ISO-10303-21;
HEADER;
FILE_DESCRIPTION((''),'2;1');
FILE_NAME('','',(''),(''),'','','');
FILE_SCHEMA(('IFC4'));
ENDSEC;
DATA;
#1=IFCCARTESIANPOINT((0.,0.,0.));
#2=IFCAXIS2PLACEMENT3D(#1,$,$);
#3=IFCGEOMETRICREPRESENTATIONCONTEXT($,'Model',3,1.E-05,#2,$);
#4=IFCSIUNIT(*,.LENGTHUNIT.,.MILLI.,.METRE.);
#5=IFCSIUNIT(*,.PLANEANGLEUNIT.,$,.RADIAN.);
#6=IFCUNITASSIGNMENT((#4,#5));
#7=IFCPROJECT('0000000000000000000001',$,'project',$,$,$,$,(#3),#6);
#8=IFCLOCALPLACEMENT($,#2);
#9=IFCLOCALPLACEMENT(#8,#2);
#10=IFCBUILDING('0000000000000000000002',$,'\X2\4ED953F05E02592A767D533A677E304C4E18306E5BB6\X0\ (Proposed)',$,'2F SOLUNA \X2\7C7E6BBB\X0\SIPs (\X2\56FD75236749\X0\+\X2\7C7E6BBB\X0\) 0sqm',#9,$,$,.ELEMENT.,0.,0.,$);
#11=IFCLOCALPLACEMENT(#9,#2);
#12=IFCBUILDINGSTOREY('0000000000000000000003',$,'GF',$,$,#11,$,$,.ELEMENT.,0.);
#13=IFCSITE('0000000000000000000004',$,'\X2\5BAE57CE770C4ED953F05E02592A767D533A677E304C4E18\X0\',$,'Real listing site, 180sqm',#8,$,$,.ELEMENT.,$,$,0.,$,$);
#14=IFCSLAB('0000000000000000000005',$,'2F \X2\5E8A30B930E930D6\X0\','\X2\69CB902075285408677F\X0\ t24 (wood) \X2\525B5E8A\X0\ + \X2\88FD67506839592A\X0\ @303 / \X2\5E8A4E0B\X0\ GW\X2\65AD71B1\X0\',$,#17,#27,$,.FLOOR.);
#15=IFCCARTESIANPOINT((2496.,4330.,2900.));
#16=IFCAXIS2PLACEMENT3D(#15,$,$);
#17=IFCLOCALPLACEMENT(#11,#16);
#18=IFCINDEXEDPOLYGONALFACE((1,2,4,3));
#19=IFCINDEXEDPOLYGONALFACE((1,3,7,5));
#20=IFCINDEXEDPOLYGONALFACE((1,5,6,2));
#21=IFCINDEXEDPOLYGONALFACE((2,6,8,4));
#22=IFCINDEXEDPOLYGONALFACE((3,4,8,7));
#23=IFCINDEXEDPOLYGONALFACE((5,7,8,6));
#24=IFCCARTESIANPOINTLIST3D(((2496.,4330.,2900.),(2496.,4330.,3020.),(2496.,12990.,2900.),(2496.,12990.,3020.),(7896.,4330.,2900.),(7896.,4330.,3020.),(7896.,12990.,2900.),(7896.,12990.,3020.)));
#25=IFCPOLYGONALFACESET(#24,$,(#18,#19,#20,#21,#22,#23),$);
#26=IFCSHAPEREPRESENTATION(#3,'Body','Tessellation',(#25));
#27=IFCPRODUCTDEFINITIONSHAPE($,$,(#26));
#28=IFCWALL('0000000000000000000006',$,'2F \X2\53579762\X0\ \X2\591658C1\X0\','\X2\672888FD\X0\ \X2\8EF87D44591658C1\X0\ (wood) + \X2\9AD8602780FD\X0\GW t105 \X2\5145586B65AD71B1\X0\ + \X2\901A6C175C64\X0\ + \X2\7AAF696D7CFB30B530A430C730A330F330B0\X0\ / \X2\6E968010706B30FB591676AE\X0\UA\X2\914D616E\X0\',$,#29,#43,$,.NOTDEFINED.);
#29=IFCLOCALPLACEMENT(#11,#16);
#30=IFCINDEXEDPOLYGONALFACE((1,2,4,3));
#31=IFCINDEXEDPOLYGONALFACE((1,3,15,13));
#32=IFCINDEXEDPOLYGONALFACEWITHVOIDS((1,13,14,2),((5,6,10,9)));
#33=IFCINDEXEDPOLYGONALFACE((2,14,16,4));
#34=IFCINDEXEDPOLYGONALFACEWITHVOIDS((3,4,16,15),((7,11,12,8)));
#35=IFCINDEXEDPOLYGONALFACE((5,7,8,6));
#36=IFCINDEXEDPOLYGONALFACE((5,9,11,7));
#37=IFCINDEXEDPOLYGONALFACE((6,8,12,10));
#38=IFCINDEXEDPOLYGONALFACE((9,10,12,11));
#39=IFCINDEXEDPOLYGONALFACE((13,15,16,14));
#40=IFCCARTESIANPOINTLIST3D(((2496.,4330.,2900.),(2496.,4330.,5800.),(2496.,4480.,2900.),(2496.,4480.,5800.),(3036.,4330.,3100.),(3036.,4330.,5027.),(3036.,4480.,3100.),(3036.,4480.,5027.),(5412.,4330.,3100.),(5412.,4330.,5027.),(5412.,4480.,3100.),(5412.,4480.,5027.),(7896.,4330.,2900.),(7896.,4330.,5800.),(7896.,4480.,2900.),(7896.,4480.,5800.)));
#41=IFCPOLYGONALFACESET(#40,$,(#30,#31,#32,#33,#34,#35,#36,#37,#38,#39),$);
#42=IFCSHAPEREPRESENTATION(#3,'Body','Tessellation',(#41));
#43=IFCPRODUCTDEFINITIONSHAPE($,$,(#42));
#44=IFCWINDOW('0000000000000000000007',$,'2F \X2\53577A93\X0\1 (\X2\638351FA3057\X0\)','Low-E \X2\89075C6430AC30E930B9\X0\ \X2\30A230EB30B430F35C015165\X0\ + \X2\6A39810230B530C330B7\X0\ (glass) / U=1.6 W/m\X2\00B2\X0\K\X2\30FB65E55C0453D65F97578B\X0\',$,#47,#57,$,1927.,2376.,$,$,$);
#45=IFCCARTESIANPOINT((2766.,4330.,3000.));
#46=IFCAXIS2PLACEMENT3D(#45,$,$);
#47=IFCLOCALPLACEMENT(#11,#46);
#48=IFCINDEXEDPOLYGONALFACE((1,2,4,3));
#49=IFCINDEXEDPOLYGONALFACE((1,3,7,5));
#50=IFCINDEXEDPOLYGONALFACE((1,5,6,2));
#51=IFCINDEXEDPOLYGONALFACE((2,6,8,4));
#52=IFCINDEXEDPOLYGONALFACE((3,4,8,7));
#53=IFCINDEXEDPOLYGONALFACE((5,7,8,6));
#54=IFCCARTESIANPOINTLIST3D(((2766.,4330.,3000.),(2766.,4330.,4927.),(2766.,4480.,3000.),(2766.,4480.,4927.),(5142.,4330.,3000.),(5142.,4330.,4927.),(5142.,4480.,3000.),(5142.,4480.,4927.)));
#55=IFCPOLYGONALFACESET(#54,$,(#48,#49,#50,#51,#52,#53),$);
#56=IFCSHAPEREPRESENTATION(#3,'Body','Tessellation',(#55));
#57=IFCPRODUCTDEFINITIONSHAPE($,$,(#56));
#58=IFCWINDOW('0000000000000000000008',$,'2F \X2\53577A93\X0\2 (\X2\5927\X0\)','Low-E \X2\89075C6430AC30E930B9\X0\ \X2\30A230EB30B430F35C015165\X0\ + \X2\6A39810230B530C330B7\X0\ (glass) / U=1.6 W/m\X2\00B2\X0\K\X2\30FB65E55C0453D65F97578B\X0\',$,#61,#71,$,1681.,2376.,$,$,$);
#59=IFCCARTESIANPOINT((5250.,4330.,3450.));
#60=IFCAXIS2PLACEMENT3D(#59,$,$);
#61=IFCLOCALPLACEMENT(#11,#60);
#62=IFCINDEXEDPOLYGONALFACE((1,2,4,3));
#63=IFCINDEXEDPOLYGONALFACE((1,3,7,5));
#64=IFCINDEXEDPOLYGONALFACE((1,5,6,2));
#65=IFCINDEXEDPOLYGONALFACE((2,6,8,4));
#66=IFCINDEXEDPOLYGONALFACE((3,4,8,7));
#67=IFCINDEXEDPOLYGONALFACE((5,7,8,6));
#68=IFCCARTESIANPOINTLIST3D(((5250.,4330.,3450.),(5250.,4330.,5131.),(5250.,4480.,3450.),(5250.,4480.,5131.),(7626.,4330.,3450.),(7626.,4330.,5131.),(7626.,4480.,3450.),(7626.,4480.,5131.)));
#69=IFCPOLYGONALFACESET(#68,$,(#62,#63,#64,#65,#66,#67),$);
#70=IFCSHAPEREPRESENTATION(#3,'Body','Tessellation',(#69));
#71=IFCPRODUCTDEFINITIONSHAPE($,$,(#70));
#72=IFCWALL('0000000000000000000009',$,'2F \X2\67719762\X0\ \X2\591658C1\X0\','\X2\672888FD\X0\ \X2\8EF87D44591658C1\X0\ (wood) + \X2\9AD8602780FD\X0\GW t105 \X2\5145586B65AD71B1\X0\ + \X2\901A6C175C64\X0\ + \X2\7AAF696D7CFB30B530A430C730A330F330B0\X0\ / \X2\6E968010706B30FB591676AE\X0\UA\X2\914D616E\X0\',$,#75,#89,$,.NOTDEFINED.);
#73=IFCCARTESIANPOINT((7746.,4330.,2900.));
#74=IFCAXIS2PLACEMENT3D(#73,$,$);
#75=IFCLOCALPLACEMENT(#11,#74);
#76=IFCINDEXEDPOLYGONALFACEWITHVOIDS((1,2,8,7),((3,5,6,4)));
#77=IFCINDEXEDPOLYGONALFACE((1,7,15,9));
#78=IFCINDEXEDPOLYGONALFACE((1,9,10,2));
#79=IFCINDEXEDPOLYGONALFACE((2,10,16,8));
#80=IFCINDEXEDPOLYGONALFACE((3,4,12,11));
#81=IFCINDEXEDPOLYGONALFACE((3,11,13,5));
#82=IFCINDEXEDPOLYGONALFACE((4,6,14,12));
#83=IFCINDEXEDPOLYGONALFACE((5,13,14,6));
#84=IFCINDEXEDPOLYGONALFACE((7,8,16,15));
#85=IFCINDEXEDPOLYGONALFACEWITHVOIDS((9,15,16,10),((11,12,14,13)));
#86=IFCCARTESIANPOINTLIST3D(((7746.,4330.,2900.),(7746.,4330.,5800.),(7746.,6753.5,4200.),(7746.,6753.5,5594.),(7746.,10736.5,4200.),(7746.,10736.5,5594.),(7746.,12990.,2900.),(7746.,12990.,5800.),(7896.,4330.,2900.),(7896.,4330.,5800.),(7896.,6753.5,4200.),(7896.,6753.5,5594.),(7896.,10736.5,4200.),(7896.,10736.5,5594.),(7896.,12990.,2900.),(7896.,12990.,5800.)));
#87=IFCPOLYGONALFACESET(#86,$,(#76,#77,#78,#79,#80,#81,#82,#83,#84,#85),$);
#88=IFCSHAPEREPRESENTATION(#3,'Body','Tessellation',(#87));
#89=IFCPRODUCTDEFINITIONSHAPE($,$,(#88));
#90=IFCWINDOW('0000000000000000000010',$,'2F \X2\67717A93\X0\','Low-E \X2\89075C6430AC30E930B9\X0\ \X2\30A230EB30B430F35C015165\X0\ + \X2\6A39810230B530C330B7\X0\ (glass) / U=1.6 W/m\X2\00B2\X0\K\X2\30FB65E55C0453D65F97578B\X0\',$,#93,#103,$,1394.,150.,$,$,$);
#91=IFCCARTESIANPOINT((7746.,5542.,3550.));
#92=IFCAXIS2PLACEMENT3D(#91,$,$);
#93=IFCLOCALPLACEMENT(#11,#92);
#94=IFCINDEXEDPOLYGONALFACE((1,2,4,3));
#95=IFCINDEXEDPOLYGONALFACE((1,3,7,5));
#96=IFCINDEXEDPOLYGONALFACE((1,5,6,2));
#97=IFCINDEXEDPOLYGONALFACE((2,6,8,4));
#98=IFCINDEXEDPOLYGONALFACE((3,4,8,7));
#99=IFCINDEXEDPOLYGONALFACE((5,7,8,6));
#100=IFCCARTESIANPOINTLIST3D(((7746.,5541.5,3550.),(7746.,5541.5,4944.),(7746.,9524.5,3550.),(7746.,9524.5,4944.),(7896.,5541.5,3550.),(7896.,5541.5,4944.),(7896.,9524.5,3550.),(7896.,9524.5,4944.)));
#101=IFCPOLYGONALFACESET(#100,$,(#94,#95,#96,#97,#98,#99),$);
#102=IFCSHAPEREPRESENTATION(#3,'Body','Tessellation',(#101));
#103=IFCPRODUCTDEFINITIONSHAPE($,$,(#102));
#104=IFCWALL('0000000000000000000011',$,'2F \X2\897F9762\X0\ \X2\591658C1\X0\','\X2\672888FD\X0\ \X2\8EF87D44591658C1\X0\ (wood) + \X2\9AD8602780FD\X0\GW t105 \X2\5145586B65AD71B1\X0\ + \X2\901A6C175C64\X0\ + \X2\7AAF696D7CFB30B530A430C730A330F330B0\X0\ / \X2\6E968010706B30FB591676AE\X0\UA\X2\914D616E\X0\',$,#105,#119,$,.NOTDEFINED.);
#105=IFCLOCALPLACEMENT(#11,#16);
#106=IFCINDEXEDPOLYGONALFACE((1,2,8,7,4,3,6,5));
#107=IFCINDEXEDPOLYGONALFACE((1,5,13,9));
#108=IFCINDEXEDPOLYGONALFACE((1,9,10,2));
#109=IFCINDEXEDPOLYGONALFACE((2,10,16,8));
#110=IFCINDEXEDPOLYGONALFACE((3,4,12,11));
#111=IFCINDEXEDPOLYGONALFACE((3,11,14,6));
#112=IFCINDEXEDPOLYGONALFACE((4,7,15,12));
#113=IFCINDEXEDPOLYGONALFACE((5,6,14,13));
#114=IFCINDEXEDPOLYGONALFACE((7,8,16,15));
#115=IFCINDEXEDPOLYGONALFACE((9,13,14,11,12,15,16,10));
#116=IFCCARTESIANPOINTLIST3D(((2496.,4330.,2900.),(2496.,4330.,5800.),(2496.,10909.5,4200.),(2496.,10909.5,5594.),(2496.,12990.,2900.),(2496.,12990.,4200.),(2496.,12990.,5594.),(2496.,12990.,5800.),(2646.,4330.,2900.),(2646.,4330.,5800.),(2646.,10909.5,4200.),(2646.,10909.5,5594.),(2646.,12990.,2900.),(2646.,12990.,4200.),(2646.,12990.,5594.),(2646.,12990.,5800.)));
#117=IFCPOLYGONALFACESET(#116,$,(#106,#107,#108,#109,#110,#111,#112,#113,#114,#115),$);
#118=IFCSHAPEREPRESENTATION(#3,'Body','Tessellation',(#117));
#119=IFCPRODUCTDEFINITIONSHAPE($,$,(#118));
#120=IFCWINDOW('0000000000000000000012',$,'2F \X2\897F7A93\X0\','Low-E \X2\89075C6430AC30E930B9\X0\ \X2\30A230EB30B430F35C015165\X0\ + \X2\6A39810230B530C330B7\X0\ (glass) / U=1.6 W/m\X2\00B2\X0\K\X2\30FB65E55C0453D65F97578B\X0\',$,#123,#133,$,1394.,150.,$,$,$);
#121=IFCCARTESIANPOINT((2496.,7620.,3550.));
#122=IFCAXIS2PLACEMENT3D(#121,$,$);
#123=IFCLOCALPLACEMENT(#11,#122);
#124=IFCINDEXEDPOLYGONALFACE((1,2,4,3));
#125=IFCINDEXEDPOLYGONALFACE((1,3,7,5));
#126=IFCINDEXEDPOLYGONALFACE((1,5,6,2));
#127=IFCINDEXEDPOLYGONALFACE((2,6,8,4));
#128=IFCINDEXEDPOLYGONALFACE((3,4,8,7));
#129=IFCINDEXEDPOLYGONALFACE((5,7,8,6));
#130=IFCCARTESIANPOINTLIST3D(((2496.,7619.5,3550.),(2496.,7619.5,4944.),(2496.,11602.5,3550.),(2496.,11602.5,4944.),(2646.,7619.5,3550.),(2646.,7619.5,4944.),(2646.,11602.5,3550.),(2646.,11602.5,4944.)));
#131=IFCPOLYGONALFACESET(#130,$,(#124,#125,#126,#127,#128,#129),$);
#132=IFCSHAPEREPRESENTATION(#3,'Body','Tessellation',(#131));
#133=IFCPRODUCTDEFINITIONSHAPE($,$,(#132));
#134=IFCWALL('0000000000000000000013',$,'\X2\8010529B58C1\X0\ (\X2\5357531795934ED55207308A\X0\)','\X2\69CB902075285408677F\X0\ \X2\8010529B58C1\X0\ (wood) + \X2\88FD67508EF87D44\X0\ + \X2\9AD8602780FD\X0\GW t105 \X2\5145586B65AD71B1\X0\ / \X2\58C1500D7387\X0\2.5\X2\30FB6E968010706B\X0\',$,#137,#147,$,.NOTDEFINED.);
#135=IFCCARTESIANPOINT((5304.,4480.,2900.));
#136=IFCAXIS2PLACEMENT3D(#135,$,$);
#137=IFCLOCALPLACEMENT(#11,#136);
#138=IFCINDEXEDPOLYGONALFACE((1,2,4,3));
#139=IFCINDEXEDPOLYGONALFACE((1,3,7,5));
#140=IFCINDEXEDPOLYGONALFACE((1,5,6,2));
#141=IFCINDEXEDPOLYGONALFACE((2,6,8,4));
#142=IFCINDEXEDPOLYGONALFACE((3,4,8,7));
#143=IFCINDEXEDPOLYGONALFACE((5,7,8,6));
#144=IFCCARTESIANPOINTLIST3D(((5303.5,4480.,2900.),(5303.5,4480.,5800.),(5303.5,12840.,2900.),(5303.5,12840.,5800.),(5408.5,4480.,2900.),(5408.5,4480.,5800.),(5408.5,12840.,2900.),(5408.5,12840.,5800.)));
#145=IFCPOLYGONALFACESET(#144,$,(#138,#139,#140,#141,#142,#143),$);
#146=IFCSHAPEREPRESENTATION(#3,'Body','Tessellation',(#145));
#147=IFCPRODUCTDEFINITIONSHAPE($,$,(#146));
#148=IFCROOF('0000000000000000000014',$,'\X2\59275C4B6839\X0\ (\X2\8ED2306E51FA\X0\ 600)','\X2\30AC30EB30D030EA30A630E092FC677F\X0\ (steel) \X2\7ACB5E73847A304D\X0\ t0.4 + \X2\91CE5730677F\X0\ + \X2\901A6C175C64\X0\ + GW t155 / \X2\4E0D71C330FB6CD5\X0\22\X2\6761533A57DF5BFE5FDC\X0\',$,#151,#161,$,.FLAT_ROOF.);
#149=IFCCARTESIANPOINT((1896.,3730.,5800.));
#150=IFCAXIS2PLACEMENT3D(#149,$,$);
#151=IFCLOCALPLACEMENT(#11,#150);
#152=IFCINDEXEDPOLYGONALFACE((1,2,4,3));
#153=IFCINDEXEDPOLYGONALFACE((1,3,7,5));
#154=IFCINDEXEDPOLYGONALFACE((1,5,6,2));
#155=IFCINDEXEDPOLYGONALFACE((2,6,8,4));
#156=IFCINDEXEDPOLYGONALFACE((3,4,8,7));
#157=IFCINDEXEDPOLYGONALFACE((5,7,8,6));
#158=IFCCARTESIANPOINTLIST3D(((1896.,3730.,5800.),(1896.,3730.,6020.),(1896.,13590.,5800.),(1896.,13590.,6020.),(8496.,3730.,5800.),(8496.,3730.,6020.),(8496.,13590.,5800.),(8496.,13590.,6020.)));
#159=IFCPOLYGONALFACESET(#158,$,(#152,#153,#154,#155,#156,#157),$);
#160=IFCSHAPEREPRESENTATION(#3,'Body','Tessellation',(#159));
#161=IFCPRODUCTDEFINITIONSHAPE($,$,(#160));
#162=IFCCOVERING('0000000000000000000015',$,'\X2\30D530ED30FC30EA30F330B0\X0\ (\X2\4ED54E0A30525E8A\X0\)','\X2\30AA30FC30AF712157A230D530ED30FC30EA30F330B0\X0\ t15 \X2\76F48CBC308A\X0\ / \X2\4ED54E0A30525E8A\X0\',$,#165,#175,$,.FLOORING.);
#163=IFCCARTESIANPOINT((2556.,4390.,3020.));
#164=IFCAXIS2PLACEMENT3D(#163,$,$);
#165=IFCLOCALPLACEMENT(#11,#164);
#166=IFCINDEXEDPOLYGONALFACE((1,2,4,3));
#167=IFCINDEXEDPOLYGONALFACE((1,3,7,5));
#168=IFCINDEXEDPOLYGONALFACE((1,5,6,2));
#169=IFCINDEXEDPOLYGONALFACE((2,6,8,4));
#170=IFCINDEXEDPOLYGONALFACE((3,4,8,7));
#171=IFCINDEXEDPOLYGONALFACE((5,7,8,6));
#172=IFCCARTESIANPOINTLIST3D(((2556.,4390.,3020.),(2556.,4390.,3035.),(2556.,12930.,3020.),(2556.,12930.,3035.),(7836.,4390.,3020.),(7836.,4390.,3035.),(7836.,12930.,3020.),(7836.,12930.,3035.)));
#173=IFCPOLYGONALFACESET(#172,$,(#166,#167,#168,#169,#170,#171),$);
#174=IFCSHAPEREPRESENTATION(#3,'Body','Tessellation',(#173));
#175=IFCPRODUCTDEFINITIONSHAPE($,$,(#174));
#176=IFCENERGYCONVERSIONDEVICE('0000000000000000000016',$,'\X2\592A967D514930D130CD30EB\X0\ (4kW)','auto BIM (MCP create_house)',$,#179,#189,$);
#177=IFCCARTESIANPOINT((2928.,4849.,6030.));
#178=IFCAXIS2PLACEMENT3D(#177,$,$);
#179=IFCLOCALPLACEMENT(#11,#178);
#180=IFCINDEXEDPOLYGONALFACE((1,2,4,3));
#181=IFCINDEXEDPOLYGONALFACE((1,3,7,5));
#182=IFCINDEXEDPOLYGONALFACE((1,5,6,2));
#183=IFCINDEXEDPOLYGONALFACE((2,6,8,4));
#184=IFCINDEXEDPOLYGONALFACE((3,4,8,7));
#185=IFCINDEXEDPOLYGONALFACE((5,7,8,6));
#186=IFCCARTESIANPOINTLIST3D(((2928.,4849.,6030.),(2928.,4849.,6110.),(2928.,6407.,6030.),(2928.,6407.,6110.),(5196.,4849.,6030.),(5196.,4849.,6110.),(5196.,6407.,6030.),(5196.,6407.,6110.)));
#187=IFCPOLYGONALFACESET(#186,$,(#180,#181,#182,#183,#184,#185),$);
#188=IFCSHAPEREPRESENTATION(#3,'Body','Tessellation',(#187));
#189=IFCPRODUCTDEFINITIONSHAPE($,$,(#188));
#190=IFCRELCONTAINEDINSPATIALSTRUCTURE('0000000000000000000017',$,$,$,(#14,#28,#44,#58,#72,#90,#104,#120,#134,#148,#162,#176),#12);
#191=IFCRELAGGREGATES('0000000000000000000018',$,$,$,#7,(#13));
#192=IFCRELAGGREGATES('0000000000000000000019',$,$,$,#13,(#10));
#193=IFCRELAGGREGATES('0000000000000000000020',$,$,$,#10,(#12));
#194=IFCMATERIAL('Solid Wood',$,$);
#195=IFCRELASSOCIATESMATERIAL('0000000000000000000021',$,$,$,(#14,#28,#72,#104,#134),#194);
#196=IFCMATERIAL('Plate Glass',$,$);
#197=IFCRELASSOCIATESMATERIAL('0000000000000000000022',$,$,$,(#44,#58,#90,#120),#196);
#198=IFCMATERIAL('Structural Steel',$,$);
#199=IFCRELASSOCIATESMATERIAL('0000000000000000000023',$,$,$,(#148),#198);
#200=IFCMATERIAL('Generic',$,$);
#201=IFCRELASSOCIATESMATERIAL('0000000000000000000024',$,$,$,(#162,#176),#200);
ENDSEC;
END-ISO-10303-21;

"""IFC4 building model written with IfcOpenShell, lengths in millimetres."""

from ifc_helpers import new_model, si_unit, frame, frame_2d, origin, place, context, project, spatial, rectangle, extrude, material, element, fill, save


model = new_model("IFC4")

# Units and contexts
model_context = context("Model", 3, precision=1e-05, world=origin())
ifc_project = project(units=[si_unit("LENGTHUNIT", "METRE", prefix="MILLI"), si_unit("PLANEANGLEUNIT", "RADIAN")], contexts=[model_context])

# Site, building, storey
site_placement = place(None, origin())
site = spatial("IfcSite", under=ifc_project, at=site_placement, Name="宮城県仙台市太白区松が丘", ObjectType="Real listing site, 180sqm", CompositionType="ELEMENT", RefElevation=0.0)
building_placement = place(site_placement, origin())
building = spatial("IfcBuilding", under=site, at=building_placement, Name="仙台市太白区松が丘の家 (Proposed)", ObjectType="2F SOLUNA 籾殻SIPs (国産杉+籾殻) 0sqm", CompositionType="ELEMENT", ElevationOfRefHeight=0.0, ElevationOfTerrain=0.0)
storey_placement = place(building_placement, origin())
storey = spatial("IfcBuildingStorey", under=building, at=storey_placement, Name="GF", CompositionType="ELEMENT", Elevation=0.0)

# Slab
ifc_material_1 = material(Name="Solid Wood")
slab_placement = place(storey_placement, frame((2496.0, 4330.0, 2900.0)))
element("IfcSlab", 1, at=slab_placement, inside=storey, material=ifc_material_1, Name="2F 床スラブ", Description="構造用合板 t24 (wood) 剛床 + 製材根太 @303 / 床下 GW断熱", PredefinedType="FLOOR", context=model_context, shape_type="SweptSolid", body=[
    extrude(rectangle(XDim=5400.0, YDim=8660.0, at=frame_2d((2700.0, 4330.0))), frame((2496.0, 4330.0, 2900.0)), (0.0, 0.0, 1.0), 120.0),
])

# Wall, openings, windows
wall_1_placement = place(storey_placement, frame((2496.0, 4330.0, 2900.0)))
wall_1 = element("IfcWall", 2, at=wall_1_placement, inside=storey, material=ifc_material_1, Name="2F 南面 外壁", Description="木製 軸組外壁 (wood) + 高性能GW t105 充填断熱 + 通気層 + 窯業系サイディング / 準耐火・外皮UA配慮", PredefinedType="NOTDEFINED", context=model_context, shape_type="SweptSolid", body=[
    extrude(rectangle(XDim=5400.0, YDim=150.0, at=frame_2d((2700.0, 75.0))), frame((2496.0, 4330.0, 2900.0)), (0.0, 0.0, 1.0), 2900.0),
])
opening_1_placement = place(storey_placement, frame((2766.0, 4330.0, 3000.0)))
opening_1 = element("IfcOpeningElement", 3, at=opening_1_placement, cuts=wall_1, PredefinedType="NOTDEFINED", context=model_context, shape_type="SweptSolid", body=[
    extrude(rectangle(XDim=2376.0, YDim=150.0, at=frame_2d((1188.0, 75.0))), frame((2766.0, 4330.0, 3000.0)), (0.0, 0.0, 1.0), 1927.0),
])
opening_2_placement = place(storey_placement, frame((5250.0, 4330.0, 3450.0)))
opening_2 = element("IfcOpeningElement", 4, at=opening_2_placement, cuts=wall_1, PredefinedType="NOTDEFINED", context=model_context, shape_type="SweptSolid", body=[
    extrude(rectangle(XDim=2376.0, YDim=150.0, at=frame_2d((1188.0, 75.0))), frame((5250.0, 4330.0, 3450.0)), (0.0, 0.0, 1.0), 1681.0),
])
ifc_material_2 = material(Name="Plate Glass")
window_1_placement = place(storey_placement, frame((2766.0, 4330.0, 3000.0)))
window_1 = element("IfcWindow", 5, at=window_1_placement, inside=storey, material=ifc_material_2, Name="2F 南窓1 (掃出し)", Description="Low-E 複層ガラス アルゴン封入 + 樹脂サッシ (glass) / U=1.6 W/m²K・日射取得型", OverallHeight=1927.0, OverallWidth=2376.0, context=model_context, shape_type="SweptSolid", body=[
    extrude(rectangle(XDim=2376.0, YDim=150.0, at=frame_2d((1188.0, 75.0))), frame((2766.0, 4330.0, 3000.0)), (0.0, 0.0, 1.0), 1927.0),
])
fill(opening_1, window_1)
window_2_placement = place(storey_placement, frame((5250.0, 4330.0, 3450.0)))
window_2 = element("IfcWindow", 6, at=window_2_placement, inside=storey, material=ifc_material_2, Name="2F 南窓2 (大)", Description="Low-E 複層ガラス アルゴン封入 + 樹脂サッシ (glass) / U=1.6 W/m²K・日射取得型", OverallHeight=1681.0, OverallWidth=2376.0, context=model_context, shape_type="SweptSolid", body=[
    extrude(rectangle(XDim=2376.0, YDim=150.0, at=frame_2d((1188.0, 75.0))), frame((5250.0, 4330.0, 3450.0)), (0.0, 0.0, 1.0), 1681.0),
])
fill(opening_2, window_2)

# Walls, openings, windows
wall_2_placement = place(storey_placement, frame((7746.0, 4330.0, 2900.0)))
wall_2 = element("IfcWall", 7, at=wall_2_placement, inside=storey, material=ifc_material_1, Name="2F 東面 外壁", Description="木製 軸組外壁 (wood) + 高性能GW t105 充填断熱 + 通気層 + 窯業系サイディング / 準耐火・外皮UA配慮", PredefinedType="NOTDEFINED", context=model_context, shape_type="SweptSolid", body=[
    extrude(rectangle(XDim=150.0, YDim=8660.0, at=frame_2d((75.0, 4330.0))), frame((7746.0, 4330.0, 2900.0)), (0.0, 0.0, 1.0), 2900.0),
])
opening_3_placement = place(storey_placement, frame((7746.0, 5542.0, 3550.0)))
opening_3 = element("IfcOpeningElement", 8, at=opening_3_placement, cuts=wall_2, PredefinedType="NOTDEFINED", context=model_context, shape_type="SweptSolid", body=[
    extrude(rectangle(XDim=150.0, YDim=3983.0, at=frame_2d((75.0, 1991.0))), frame((7746.0, 5542.0, 3550.0)), (0.0, 0.0, 1.0), 1394.0),
])
window_3_placement = place(storey_placement, frame((7746.0, 5542.0, 3550.0)))
window_3 = element("IfcWindow", 9, at=window_3_placement, inside=storey, material=ifc_material_2, Name="2F 東窓", Description="Low-E 複層ガラス アルゴン封入 + 樹脂サッシ (glass) / U=1.6 W/m²K・日射取得型", OverallHeight=1394.0, OverallWidth=150.0, context=model_context, shape_type="SweptSolid", body=[
    extrude(rectangle(XDim=150.0, YDim=3983.0, at=frame_2d((75.0, 1991.0))), frame((7746.0, 5542.0, 3550.0)), (0.0, 0.0, 1.0), 1394.0),
])
fill(opening_3, window_3)
wall_3_placement = place(storey_placement, frame((2496.0, 4330.0, 2900.0)))
wall_3 = element("IfcWall", 10, at=wall_3_placement, inside=storey, material=ifc_material_1, Name="2F 西面 外壁", Description="木製 軸組外壁 (wood) + 高性能GW t105 充填断熱 + 通気層 + 窯業系サイディング / 準耐火・外皮UA配慮", PredefinedType="NOTDEFINED", context=model_context, shape_type="SweptSolid", body=[
    extrude(rectangle(XDim=150.0, YDim=8660.0, at=frame_2d((75.0, 4330.0))), frame((2496.0, 4330.0, 2900.0)), (0.0, 0.0, 1.0), 2900.0),
])
opening_4_placement = place(storey_placement, frame((2496.0, 7620.0, 3550.0)))
opening_4 = element("IfcOpeningElement", 11, at=opening_4_placement, cuts=wall_3, PredefinedType="NOTDEFINED", context=model_context, shape_type="SweptSolid", body=[
    extrude(rectangle(XDim=150.0, YDim=3983.0, at=frame_2d((75.0, 1991.0))), frame((2496.0, 7620.0, 3550.0)), (0.0, 0.0, 1.0), 1394.0),
])
window_4_placement = place(storey_placement, frame((2496.0, 7620.0, 3550.0)))
window_4 = element("IfcWindow", 12, at=window_4_placement, inside=storey, material=ifc_material_2, Name="2F 西窓", Description="Low-E 複層ガラス アルゴン封入 + 樹脂サッシ (glass) / U=1.6 W/m²K・日射取得型", OverallHeight=1394.0, OverallWidth=150.0, context=model_context, shape_type="SweptSolid", body=[
    extrude(rectangle(XDim=150.0, YDim=3983.0, at=frame_2d((75.0, 1991.0))), frame((2496.0, 7620.0, 3550.0)), (0.0, 0.0, 1.0), 1394.0),
])
fill(opening_4, window_4)

# Wall
wall_4_placement = place(storey_placement, frame((5304.0, 4480.0, 2900.0)))
element("IfcWall", 13, at=wall_4_placement, inside=storey, material=ifc_material_1, Name="耐力壁 (南北間仕切り)", Description="構造用合板 耐力壁 (wood) + 製材軸組 + 高性能GW t105 充填断熱 / 壁倍率2.5・準耐火", PredefinedType="NOTDEFINED", context=model_context, shape_type="SweptSolid", body=[
    extrude(rectangle(XDim=105.0, YDim=8360.0, at=frame_2d((52.0, 4180.0))), frame((5304.0, 4480.0, 2900.0)), (0.0, 0.0, 1.0), 2900.0),
])

# Roof
ifc_material_3 = material(Name="Structural Steel")
roof_placement = place(storey_placement, frame((1896.0, 3730.0, 5800.0)))
element("IfcRoof", 14, at=roof_placement, inside=storey, material=ifc_material_3, Name="大屋根 (軒の出 600)", Description="ガルバリウム鋼板 (steel) 立平葺き t0.4 + 野地板 + 通気層 + GW t155 / 不燃・法22条区域対応", PredefinedType="FLAT_ROOF", context=model_context, shape_type="SweptSolid", body=[
    extrude(rectangle(XDim=6600.0, YDim=9860.0, at=frame_2d((3300.0, 4930.0))), frame((1896.0, 3730.0, 5800.0)), (0.0, 0.0, 1.0), 220.0),
])

# Covering
ifc_material_4 = material(Name="Generic")
covering_placement = place(storey_placement, frame((2556.0, 4390.0, 3020.0)))
element("IfcCovering", 15, at=covering_placement, inside=storey, material=ifc_material_4, Name="フローリング (仕上げ床)", Description="オーク無垢フローリング t15 直貼り / 仕上げ床", PredefinedType="FLOORING", context=model_context, shape_type="SweptSolid", body=[
    extrude(rectangle(XDim=5280.0, YDim=8540.0, at=frame_2d((2640.0, 4270.0))), frame((2556.0, 4390.0, 3020.0)), (0.0, 0.0, 1.0), 15.0),
])

# Energy conversion device
energy_conversion_device_placement = place(storey_placement, frame((2928.0, 4849.0, 6030.0)))
element("IfcEnergyConversionDevice", 16, at=energy_conversion_device_placement, inside=storey, material=ifc_material_4, Name="太陽光パネル (4kW)", Description="auto BIM (MCP create_house)", context=model_context, shape_type="SweptSolid", body=[
    extrude(rectangle(XDim=2268.0, YDim=1558.0, at=frame_2d((1134.0, 779.0))), frame((2928.0, 4849.0, 6030.0)), (0.0, 0.0, 1.0), 80.0),
])

save(model, "model.ifc")
